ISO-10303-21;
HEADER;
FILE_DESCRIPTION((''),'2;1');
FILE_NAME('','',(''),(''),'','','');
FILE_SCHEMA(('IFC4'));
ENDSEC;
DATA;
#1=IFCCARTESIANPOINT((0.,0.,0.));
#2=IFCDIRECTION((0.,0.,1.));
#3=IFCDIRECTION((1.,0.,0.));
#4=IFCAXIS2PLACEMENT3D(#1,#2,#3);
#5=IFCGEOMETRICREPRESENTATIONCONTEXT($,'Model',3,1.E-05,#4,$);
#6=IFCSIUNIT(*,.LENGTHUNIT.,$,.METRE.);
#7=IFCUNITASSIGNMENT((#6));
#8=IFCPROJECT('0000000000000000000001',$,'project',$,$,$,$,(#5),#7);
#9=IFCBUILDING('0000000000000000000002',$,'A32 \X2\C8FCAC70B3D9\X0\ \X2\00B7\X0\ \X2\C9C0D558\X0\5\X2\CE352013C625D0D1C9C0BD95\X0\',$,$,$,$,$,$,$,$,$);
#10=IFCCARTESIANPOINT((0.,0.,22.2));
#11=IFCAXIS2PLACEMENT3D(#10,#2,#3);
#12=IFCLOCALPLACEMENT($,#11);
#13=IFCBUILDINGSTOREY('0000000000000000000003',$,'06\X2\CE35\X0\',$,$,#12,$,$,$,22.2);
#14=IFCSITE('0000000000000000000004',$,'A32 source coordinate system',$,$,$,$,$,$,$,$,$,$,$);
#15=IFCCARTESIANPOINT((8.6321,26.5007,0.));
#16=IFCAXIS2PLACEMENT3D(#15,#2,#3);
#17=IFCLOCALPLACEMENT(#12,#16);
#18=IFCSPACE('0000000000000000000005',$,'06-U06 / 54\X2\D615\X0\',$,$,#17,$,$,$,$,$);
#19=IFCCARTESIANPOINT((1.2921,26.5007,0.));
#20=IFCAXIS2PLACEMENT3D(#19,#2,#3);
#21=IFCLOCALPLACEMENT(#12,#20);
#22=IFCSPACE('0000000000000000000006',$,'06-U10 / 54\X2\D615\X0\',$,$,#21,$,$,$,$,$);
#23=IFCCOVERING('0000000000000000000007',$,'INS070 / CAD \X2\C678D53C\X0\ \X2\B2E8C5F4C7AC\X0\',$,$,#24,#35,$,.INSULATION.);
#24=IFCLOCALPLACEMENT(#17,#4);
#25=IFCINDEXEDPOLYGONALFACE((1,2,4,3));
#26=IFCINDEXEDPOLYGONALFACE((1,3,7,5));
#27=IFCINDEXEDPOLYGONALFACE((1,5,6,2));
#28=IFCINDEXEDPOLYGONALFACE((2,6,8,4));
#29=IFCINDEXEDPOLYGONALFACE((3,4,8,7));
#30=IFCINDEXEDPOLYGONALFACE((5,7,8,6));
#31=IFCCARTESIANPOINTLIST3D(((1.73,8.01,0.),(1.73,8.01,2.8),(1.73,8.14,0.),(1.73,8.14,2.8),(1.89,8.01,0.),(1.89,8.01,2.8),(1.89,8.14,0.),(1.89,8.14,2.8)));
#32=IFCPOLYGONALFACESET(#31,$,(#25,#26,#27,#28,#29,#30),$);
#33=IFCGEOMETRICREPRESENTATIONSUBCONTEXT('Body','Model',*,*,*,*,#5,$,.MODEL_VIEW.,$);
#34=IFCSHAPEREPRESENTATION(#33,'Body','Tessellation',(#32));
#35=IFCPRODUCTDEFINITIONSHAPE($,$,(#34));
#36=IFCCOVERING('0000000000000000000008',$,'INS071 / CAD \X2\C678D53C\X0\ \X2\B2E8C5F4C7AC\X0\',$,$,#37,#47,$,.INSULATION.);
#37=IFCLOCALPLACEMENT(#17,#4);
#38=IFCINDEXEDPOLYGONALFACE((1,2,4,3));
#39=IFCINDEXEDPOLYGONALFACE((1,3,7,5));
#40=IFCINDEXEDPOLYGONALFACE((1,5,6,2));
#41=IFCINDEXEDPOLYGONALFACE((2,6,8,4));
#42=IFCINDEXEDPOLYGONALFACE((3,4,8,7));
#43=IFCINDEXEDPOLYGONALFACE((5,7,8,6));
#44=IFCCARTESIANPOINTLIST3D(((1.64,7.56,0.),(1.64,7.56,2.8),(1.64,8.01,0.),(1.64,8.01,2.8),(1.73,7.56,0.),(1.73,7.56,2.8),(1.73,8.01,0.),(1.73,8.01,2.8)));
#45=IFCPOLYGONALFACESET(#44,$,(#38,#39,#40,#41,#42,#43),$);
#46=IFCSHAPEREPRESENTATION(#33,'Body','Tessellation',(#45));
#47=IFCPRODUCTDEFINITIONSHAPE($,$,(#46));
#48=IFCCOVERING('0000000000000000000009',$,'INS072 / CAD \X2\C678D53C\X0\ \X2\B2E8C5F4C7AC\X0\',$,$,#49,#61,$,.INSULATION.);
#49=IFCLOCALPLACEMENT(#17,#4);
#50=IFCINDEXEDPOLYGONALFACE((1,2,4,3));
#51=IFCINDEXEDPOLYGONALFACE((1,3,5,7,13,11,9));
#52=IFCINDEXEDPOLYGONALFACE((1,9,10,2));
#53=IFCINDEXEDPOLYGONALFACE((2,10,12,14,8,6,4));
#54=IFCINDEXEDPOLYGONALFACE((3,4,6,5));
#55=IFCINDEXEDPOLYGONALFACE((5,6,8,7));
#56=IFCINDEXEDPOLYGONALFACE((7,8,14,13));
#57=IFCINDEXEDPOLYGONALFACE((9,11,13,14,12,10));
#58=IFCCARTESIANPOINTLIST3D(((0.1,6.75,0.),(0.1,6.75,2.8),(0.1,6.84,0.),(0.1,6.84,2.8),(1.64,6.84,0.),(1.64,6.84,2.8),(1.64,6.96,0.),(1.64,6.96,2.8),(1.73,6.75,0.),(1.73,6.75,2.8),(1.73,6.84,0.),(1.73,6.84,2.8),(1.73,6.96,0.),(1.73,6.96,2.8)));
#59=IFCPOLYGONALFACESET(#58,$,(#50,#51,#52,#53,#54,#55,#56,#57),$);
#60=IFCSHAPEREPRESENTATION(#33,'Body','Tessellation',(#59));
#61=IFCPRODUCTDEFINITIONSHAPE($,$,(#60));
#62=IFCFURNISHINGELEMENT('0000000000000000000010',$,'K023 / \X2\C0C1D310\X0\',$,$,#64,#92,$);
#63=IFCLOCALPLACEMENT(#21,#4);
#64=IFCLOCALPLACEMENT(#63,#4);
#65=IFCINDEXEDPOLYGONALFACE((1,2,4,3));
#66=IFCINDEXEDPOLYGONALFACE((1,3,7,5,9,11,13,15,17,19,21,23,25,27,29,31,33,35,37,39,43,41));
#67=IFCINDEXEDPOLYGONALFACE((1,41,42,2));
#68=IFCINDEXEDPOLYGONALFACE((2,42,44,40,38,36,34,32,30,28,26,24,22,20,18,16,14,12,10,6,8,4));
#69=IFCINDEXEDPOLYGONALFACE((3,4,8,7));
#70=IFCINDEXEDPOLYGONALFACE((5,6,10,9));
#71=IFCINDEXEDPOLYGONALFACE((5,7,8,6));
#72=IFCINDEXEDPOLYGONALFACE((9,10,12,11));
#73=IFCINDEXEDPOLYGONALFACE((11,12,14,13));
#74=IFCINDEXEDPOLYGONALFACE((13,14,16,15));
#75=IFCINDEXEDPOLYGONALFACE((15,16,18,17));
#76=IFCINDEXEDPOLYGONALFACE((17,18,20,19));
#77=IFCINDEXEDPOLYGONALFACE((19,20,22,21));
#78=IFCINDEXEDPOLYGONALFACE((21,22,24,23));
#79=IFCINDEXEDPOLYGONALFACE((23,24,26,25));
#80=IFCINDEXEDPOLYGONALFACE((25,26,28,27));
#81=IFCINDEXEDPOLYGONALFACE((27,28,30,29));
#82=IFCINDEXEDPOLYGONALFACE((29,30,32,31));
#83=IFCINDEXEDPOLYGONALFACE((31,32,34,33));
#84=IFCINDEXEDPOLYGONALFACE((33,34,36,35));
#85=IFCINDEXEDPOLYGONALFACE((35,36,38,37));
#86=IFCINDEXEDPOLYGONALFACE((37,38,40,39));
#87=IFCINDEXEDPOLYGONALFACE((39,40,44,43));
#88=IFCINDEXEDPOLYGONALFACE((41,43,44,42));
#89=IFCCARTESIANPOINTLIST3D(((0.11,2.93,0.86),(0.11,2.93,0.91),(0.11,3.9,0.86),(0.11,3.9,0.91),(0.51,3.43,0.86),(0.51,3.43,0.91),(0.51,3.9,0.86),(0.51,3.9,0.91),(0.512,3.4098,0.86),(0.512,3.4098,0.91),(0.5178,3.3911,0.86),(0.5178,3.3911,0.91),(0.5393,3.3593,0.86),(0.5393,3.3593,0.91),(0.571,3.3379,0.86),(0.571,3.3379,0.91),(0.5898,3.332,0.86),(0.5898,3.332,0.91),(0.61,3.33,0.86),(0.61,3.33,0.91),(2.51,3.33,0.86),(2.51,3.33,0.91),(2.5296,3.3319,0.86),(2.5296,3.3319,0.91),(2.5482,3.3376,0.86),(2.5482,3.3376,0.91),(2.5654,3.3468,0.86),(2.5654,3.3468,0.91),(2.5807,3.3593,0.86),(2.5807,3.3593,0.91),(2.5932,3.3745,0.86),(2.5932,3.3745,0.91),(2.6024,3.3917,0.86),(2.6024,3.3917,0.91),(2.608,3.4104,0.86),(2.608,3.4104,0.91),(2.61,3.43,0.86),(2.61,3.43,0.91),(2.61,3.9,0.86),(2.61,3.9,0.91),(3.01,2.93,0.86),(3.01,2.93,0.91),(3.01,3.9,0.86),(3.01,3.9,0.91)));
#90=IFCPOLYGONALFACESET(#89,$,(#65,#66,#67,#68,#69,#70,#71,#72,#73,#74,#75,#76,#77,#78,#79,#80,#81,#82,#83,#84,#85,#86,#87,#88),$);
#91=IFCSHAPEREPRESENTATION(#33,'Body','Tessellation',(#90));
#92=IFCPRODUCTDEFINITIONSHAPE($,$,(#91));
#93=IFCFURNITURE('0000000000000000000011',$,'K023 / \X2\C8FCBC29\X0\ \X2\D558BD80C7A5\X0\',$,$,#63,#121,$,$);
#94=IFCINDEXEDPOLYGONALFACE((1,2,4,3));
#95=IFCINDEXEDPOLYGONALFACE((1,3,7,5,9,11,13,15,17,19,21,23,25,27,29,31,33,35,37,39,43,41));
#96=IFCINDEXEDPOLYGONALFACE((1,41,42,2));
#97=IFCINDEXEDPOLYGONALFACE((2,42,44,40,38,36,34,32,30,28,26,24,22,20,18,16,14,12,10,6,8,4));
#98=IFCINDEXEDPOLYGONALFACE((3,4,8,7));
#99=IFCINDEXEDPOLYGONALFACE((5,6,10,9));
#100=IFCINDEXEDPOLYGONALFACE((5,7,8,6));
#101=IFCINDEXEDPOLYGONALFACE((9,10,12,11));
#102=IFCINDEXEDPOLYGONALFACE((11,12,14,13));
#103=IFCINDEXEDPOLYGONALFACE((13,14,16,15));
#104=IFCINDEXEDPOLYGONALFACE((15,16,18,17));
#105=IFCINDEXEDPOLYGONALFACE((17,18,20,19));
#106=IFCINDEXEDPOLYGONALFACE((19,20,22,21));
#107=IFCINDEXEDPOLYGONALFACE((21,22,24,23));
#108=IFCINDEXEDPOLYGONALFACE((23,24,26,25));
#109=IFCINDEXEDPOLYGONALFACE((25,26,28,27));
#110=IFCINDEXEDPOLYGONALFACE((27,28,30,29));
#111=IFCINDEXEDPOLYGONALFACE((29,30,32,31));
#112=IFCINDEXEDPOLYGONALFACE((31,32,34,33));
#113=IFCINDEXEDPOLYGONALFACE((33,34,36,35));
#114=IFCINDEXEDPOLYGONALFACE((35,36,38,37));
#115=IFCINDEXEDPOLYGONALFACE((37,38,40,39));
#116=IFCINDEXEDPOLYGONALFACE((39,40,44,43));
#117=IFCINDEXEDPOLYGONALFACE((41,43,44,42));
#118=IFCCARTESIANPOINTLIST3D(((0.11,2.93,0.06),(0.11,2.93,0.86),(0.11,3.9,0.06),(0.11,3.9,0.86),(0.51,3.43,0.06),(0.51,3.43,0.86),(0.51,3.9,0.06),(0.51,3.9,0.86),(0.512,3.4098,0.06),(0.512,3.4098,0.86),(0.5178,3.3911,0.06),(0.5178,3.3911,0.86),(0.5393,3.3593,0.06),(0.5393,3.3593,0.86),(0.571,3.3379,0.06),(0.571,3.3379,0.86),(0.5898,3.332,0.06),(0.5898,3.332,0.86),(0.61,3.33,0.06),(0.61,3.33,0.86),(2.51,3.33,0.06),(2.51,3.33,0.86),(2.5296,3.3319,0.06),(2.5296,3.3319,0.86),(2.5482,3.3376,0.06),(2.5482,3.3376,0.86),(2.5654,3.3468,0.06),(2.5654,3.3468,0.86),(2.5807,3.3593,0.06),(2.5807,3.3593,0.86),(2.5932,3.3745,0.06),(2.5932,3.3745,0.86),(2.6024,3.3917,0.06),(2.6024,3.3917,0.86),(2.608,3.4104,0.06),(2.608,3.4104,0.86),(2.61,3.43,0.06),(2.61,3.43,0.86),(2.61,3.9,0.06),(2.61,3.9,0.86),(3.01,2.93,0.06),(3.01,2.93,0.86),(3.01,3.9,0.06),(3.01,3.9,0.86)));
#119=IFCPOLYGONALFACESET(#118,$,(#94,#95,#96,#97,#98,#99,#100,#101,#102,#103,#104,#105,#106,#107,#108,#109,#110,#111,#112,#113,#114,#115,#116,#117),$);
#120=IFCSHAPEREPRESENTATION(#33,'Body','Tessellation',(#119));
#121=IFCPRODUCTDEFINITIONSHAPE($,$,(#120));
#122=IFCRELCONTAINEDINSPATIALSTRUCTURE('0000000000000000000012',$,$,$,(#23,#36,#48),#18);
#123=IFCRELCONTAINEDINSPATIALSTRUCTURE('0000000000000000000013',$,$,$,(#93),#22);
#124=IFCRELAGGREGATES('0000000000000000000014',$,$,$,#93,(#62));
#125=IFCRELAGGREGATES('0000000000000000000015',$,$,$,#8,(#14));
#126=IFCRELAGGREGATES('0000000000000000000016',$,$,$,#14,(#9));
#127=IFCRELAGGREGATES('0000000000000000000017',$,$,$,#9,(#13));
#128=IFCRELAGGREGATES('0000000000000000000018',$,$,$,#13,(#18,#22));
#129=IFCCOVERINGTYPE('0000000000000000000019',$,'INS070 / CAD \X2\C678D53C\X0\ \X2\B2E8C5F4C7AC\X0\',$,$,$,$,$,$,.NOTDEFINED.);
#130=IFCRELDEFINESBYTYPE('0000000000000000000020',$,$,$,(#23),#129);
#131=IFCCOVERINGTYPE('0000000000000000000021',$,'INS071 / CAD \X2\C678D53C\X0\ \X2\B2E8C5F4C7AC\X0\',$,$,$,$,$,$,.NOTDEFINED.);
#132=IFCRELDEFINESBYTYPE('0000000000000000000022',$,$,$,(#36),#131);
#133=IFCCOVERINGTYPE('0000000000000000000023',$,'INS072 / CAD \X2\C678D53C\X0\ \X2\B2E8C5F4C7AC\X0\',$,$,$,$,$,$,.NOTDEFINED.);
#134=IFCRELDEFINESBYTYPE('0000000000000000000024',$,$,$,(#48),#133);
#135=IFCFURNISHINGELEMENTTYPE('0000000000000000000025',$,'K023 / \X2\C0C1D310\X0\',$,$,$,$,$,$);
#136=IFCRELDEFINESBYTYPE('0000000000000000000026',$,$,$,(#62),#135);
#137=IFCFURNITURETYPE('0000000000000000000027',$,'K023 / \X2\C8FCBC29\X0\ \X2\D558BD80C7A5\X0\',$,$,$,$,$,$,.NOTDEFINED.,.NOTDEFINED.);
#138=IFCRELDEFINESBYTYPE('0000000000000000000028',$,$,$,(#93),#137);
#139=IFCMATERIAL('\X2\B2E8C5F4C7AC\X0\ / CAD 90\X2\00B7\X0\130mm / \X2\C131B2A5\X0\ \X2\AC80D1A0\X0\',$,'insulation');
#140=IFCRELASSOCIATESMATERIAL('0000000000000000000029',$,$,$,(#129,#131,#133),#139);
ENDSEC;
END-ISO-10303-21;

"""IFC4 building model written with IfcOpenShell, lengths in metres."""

from ifc_helpers import new_model, si_unit, frame, origin, origin_with_axes, place, context, subcontext, project, spatial, polyline, outline, extrude, source, transform, mapped, material, type_object, type_shapes, element, aggregate, save


model = new_model("IFC4")

# Units and contexts
model_context = context("Model", 3, precision=1e-05, world=origin_with_axes())
body_context = subcontext(model_context, "Body", "Model", "MODEL_VIEW")
ifc_project = project(units=[si_unit("LENGTHUNIT", "METRE")], contexts=[model_context])

# Site, building, storey, space
storey_placement = place(None, frame((0.0, 0.0, 22.2), z_axis=(0.0, 0.0, 1.0), x_axis=(1.0, 0.0, 0.0)))
space_1_placement = place(storey_placement, frame((8.6321, 26.5007, 0.0), z_axis=(0.0, 0.0, 1.0), x_axis=(1.0, 0.0, 0.0)))
site = spatial("IfcSite", under=ifc_project, Name="A32 source coordinate system")
building = spatial("IfcBuilding", under=site, Name="A32 주거동 · 지하5층–옥탑지붕")
storey = spatial("IfcBuildingStorey", under=building, at=storey_placement, Name="06층", Elevation=22.2)
space_1 = spatial("IfcSpace", under=storey, at=space_1_placement, Name="06-U06 / 54형")

# Coverings
ifc_material = material(Name="단열재 / CAD 90·130mm / 성능 검토", Category="insulation")
covering_type_1 = type_object("IfcCoveringType", Name="INS070 / CAD 외피 단열재", PredefinedType="NOTDEFINED", material=ifc_material)
shared_shape_1 = source(origin(), body_context, "Body", "SweptSolid", [
    extrude(outline(polyline([(1.73, 8.14), (1.89, 8.14), (1.89, 8.01), (1.73, 8.01), (1.73, 8.14)])), origin(), (0.0, 0.0, 1.0), 2.8),
])
type_shapes(covering_type_1, [shared_shape_1])
covering_1_placement = place(space_1_placement, origin_with_axes())
element("IfcCovering", 1, at=covering_1_placement, inside=space_1, type_object=covering_type_1, Name="INS070 / CAD 외피 단열재", PredefinedType="INSULATION", context=body_context, shape_type="MappedRepresentation", body=[
    mapped(shared_shape_1, transform((0.0, 0.0, 0.0), scale=1.0)),
])
covering_type_2 = type_object("IfcCoveringType", Name="INS071 / CAD 외피 단열재", PredefinedType="NOTDEFINED", material=ifc_material)
shared_shape_2 = source(origin(), body_context, "Body", "SweptSolid", [
    extrude(outline(polyline([(1.73, 7.56), (1.64, 7.56), (1.64, 8.01), (1.73, 8.01), (1.73, 7.56)])), origin(), (0.0, 0.0, 1.0), 2.8),
])
type_shapes(covering_type_2, [shared_shape_2])
covering_2_placement = place(space_1_placement, origin_with_axes())
element("IfcCovering", 2, at=covering_2_placement, inside=space_1, type_object=covering_type_2, Name="INS071 / CAD 외피 단열재", PredefinedType="INSULATION", context=body_context, shape_type="MappedRepresentation", body=[
    mapped(shared_shape_2, transform((0.0, 0.0, 0.0), scale=1.0)),
])
covering_type_3 = type_object("IfcCoveringType", Name="INS072 / CAD 외피 단열재", PredefinedType="NOTDEFINED", material=ifc_material)
shared_shape_3 = source(origin(), body_context, "Body", "SweptSolid", [
    extrude(outline(polyline([(1.64, 6.84), (1.64, 6.96), (1.73, 6.96), (1.73, 6.84), (1.73, 6.75), (0.1, 6.75), (0.1, 6.84), (1.64, 6.84)])), origin(), (0.0, 0.0, 1.0), 2.8),
])
type_shapes(covering_type_3, [shared_shape_3])
covering_3_placement = place(space_1_placement, origin_with_axes())
element("IfcCovering", 3, at=covering_3_placement, inside=space_1, type_object=covering_type_3, Name="INS072 / CAD 외피 단열재", PredefinedType="INSULATION", context=body_context, shape_type="MappedRepresentation", body=[
    mapped(shared_shape_3, transform((0.0, 0.0, 0.0), scale=1.0)),
])

# Shared definitions
space_2_placement = place(storey_placement, frame((1.2921, 26.5007, 0.0), z_axis=(0.0, 0.0, 1.0), x_axis=(1.0, 0.0, 0.0)))

# Furnishing element
furnishing_element_type_1 = type_object("IfcFurnishingElementType", Name="K023 / 상판")
shared_shape_4 = source(origin(), body_context, "Body", "SweptSolid", [
    extrude(outline(polyline([(0.51, 3.43), (0.512, 3.4098), (0.5178, 3.3911), (0.5393, 3.3593), (0.571, 3.3379), (0.5898, 3.332), (0.61, 3.33), (2.51, 3.33), (2.5296, 3.3319), (2.5482, 3.3376), (2.5654, 3.3468), (2.5807, 3.3593), (2.5932, 3.3745), (2.6024, 3.3917), (2.608, 3.4104), (2.61, 3.43), (2.61, 3.9), (3.01, 3.9), (3.01, 2.93), (0.11, 2.93), (0.11, 3.9), (0.51, 3.9), (0.51, 3.43)])), frame((0.0, 0.0, 0.86)), (0.0, 0.0, 1.0), 0.05),
])
type_shapes(furnishing_element_type_1, [shared_shape_4])
furniture_1_placement = place(space_2_placement, origin_with_axes())
furnishing_1_placement = place(furniture_1_placement, origin_with_axes())
furnishing_1 = element("IfcFurnishingElement", 4, at=furnishing_1_placement, type_object=furnishing_element_type_1, Name="K023 / 상판", context=body_context, shape_type="MappedRepresentation", body=[
    mapped(shared_shape_4, transform((0.0, 0.0, 0.0), scale=1.0)),
])

# Shared definitions
space_2 = spatial("IfcSpace", under=storey, at=space_2_placement, Name="06-U10 / 54형")

# Furniture
furniture_type_1 = type_object("IfcFurnitureType", Name="K023 / 주방 하부장", AssemblyPlace="NOTDEFINED", PredefinedType="NOTDEFINED")
shared_shape_5 = source(origin(), body_context, "Body", "SweptSolid", [
    extrude(outline(polyline([(0.51, 3.9), (0.51, 3.43), (0.512, 3.4098), (0.5178, 3.3911), (0.5393, 3.3593), (0.571, 3.3379), (0.5898, 3.332), (0.61, 3.33), (2.51, 3.33), (2.5296, 3.3319), (2.5482, 3.3376), (2.5654, 3.3468), (2.5807, 3.3593), (2.5932, 3.3745), (2.6024, 3.3917), (2.608, 3.4104), (2.61, 3.43), (2.61, 3.9), (3.01, 3.9), (3.01, 2.93), (0.11, 2.93), (0.11, 3.9), (0.51, 3.9)])), frame((0.0, 0.0, 0.06)), (0.0, 0.0, 1.0), 0.8),
])
type_shapes(furniture_type_1, [shared_shape_5])
furniture_1 = element("IfcFurniture", 5, at=furniture_1_placement, inside=space_2, type_object=furniture_type_1, Name="K023 / 주방 하부장", context=body_context, shape_type="MappedRepresentation", body=[
    mapped(shared_shape_5, transform((0.0, 0.0, 0.0), scale=1.0)),
])
aggregate(furniture_1, [furnishing_1])

save(model, "model.ifc")
